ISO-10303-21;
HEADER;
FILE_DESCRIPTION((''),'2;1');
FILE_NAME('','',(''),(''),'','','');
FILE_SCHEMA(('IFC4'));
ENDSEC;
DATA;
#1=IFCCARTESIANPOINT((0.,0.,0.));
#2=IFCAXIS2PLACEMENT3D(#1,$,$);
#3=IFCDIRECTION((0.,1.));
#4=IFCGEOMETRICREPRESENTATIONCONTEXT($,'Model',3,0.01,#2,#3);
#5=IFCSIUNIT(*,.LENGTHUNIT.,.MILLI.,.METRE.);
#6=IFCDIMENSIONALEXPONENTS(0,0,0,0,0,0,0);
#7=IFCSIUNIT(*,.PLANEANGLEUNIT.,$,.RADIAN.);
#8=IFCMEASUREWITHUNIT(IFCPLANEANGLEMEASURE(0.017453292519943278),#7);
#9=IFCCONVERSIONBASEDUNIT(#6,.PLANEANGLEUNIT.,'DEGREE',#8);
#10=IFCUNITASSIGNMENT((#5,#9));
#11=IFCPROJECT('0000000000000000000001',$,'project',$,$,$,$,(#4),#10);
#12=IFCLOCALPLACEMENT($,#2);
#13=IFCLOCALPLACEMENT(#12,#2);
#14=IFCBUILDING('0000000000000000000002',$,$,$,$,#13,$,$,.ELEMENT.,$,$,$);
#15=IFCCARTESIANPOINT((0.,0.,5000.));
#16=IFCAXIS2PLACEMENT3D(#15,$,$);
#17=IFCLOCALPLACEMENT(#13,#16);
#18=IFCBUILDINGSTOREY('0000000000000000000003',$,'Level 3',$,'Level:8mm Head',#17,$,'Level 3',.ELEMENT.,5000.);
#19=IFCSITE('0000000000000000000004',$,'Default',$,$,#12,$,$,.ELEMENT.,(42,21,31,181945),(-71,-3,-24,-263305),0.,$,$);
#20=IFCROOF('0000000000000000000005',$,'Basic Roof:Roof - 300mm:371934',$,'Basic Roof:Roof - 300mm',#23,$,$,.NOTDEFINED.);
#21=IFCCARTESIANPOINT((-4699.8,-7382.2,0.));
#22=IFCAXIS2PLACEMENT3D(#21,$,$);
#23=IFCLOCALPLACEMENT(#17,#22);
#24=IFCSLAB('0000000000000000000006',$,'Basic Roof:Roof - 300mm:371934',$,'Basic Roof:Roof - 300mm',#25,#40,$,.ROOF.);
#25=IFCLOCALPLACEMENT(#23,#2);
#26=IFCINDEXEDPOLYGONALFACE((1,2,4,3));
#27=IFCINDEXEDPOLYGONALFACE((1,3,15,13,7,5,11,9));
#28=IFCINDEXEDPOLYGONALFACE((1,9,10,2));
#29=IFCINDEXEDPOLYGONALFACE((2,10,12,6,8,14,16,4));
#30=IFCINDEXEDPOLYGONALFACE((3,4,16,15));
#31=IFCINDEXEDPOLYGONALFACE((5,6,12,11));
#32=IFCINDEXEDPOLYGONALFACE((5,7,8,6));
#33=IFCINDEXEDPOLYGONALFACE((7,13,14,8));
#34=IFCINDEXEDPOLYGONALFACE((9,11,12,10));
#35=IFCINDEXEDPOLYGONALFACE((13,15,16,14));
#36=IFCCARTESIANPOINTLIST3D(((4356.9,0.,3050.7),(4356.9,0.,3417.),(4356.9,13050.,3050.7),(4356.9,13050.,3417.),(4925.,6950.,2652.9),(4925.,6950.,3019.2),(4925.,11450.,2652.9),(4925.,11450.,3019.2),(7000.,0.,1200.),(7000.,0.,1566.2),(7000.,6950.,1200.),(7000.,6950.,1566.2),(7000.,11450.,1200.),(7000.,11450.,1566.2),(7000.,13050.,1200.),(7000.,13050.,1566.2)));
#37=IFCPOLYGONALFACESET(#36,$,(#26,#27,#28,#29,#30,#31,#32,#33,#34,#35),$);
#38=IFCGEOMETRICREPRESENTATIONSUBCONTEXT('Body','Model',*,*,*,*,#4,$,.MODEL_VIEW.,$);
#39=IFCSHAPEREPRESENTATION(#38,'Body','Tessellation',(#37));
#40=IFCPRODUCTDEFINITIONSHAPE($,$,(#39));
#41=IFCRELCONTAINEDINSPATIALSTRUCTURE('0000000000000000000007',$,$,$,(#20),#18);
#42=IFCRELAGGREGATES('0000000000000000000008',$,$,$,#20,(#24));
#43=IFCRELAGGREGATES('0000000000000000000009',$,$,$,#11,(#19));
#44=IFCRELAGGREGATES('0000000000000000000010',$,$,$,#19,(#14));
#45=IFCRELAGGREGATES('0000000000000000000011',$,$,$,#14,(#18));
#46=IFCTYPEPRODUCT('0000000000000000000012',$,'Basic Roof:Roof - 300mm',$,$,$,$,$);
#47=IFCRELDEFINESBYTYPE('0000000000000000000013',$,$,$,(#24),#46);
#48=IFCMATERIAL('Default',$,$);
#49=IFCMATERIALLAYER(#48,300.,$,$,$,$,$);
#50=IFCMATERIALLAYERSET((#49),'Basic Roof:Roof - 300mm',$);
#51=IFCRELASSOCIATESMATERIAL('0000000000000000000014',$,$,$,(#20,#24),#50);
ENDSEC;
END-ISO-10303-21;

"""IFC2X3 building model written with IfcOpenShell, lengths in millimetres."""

from ifc_helpers import new_model, entity, si_unit, converted_unit, direction, frame, origin, place, context, subcontext, project, spatial, polyline, outline, extrude, material, layer, layer_set, type_object, element, aggregate, save


model = new_model("IFC2X3")

# Units and contexts
model_context = context("Model", 3, precision=0.01, world=origin(), true_north=direction((0.0, 1.0)))
body_context = subcontext(model_context, "Body", "Model", "MODEL_VIEW")
ifc_project = project(units=[si_unit("LENGTHUNIT", "METRE", prefix="MILLI"), converted_unit("PLANEANGLEUNIT", "DEGREE", entity("IfcPlaneAngleMeasure", 0.017453292519943278), si_unit("PLANEANGLEUNIT", "RADIAN"), dimensions=[0, 0, 0, 0, 0, 0, 0])], contexts=[model_context])

# Site, building, storey
site_placement = place(None, origin())
site = spatial("IfcSite", under=ifc_project, at=site_placement, Name="Default", CompositionType="ELEMENT", RefLatitude=(42, 21, 31, 181945), RefLongitude=(-71, -3, -24, -263305), RefElevation=0.0)
building_placement = place(site_placement, origin())
building = spatial("IfcBuilding", under=site, at=building_placement, CompositionType="ELEMENT")
storey_placement = place(building_placement, frame((0.0, 0.0, 5000.0)))
storey = spatial("IfcBuildingStorey", under=building, at=storey_placement, Name="Level 3", ObjectType="Level:8mm Head", LongName="Level 3", CompositionType="ELEMENT", Elevation=5000.0)

# Roof, slab
ifc_material = material(Name="Default")
ifc_layer = layer(ifc_material, 300.0)
ifc_layer_set = layer_set([ifc_layer], Name="Basic Roof:Roof - 300mm")
roof_placement = place(storey_placement, frame((-4699.8, -7382.2, 0.0)))
roof = element("IfcRoof", 1, at=roof_placement, inside=storey, material=ifc_layer_set, Name="Basic Roof:Roof - 300mm:371934", ObjectType="Basic Roof:Roof - 300mm", ShapeType="NOTDEFINED")
type_product = type_object("IfcTypeProduct", Name="Basic Roof:Roof - 300mm")
slab_1_placement = place(roof_placement, origin())
slab_1 = element("IfcSlab", 2, at=slab_1_placement, type_object=type_product, material=ifc_layer_set, Name="Basic Roof:Roof - 300mm:371934", ObjectType="Basic Roof:Roof - 300mm", PredefinedType="ROOF", context=body_context, shape_type="SweptSolid", body=[
    extrude(outline(polyline([(-1613.3, 6525.0), (-1613.3, -6525.0), (1613.3, -6525.0), (1613.3, 425.0), (-919.8, 425.0), (-919.8, 4925.0), (1613.3, 4925.0), (1613.3, 6525.0), (-1613.3, 6525.0)])), frame((5678.4, 6525.0, 2125.4), z_axis=(0.573576, 0.0, 0.819152), x_axis=(0.819152, 0.0, -0.573576)), (-0.573576, 0.0, 0.819152), 366.2),
])
aggregate(roof, [slab_1])

save(model, "model.ifc")
